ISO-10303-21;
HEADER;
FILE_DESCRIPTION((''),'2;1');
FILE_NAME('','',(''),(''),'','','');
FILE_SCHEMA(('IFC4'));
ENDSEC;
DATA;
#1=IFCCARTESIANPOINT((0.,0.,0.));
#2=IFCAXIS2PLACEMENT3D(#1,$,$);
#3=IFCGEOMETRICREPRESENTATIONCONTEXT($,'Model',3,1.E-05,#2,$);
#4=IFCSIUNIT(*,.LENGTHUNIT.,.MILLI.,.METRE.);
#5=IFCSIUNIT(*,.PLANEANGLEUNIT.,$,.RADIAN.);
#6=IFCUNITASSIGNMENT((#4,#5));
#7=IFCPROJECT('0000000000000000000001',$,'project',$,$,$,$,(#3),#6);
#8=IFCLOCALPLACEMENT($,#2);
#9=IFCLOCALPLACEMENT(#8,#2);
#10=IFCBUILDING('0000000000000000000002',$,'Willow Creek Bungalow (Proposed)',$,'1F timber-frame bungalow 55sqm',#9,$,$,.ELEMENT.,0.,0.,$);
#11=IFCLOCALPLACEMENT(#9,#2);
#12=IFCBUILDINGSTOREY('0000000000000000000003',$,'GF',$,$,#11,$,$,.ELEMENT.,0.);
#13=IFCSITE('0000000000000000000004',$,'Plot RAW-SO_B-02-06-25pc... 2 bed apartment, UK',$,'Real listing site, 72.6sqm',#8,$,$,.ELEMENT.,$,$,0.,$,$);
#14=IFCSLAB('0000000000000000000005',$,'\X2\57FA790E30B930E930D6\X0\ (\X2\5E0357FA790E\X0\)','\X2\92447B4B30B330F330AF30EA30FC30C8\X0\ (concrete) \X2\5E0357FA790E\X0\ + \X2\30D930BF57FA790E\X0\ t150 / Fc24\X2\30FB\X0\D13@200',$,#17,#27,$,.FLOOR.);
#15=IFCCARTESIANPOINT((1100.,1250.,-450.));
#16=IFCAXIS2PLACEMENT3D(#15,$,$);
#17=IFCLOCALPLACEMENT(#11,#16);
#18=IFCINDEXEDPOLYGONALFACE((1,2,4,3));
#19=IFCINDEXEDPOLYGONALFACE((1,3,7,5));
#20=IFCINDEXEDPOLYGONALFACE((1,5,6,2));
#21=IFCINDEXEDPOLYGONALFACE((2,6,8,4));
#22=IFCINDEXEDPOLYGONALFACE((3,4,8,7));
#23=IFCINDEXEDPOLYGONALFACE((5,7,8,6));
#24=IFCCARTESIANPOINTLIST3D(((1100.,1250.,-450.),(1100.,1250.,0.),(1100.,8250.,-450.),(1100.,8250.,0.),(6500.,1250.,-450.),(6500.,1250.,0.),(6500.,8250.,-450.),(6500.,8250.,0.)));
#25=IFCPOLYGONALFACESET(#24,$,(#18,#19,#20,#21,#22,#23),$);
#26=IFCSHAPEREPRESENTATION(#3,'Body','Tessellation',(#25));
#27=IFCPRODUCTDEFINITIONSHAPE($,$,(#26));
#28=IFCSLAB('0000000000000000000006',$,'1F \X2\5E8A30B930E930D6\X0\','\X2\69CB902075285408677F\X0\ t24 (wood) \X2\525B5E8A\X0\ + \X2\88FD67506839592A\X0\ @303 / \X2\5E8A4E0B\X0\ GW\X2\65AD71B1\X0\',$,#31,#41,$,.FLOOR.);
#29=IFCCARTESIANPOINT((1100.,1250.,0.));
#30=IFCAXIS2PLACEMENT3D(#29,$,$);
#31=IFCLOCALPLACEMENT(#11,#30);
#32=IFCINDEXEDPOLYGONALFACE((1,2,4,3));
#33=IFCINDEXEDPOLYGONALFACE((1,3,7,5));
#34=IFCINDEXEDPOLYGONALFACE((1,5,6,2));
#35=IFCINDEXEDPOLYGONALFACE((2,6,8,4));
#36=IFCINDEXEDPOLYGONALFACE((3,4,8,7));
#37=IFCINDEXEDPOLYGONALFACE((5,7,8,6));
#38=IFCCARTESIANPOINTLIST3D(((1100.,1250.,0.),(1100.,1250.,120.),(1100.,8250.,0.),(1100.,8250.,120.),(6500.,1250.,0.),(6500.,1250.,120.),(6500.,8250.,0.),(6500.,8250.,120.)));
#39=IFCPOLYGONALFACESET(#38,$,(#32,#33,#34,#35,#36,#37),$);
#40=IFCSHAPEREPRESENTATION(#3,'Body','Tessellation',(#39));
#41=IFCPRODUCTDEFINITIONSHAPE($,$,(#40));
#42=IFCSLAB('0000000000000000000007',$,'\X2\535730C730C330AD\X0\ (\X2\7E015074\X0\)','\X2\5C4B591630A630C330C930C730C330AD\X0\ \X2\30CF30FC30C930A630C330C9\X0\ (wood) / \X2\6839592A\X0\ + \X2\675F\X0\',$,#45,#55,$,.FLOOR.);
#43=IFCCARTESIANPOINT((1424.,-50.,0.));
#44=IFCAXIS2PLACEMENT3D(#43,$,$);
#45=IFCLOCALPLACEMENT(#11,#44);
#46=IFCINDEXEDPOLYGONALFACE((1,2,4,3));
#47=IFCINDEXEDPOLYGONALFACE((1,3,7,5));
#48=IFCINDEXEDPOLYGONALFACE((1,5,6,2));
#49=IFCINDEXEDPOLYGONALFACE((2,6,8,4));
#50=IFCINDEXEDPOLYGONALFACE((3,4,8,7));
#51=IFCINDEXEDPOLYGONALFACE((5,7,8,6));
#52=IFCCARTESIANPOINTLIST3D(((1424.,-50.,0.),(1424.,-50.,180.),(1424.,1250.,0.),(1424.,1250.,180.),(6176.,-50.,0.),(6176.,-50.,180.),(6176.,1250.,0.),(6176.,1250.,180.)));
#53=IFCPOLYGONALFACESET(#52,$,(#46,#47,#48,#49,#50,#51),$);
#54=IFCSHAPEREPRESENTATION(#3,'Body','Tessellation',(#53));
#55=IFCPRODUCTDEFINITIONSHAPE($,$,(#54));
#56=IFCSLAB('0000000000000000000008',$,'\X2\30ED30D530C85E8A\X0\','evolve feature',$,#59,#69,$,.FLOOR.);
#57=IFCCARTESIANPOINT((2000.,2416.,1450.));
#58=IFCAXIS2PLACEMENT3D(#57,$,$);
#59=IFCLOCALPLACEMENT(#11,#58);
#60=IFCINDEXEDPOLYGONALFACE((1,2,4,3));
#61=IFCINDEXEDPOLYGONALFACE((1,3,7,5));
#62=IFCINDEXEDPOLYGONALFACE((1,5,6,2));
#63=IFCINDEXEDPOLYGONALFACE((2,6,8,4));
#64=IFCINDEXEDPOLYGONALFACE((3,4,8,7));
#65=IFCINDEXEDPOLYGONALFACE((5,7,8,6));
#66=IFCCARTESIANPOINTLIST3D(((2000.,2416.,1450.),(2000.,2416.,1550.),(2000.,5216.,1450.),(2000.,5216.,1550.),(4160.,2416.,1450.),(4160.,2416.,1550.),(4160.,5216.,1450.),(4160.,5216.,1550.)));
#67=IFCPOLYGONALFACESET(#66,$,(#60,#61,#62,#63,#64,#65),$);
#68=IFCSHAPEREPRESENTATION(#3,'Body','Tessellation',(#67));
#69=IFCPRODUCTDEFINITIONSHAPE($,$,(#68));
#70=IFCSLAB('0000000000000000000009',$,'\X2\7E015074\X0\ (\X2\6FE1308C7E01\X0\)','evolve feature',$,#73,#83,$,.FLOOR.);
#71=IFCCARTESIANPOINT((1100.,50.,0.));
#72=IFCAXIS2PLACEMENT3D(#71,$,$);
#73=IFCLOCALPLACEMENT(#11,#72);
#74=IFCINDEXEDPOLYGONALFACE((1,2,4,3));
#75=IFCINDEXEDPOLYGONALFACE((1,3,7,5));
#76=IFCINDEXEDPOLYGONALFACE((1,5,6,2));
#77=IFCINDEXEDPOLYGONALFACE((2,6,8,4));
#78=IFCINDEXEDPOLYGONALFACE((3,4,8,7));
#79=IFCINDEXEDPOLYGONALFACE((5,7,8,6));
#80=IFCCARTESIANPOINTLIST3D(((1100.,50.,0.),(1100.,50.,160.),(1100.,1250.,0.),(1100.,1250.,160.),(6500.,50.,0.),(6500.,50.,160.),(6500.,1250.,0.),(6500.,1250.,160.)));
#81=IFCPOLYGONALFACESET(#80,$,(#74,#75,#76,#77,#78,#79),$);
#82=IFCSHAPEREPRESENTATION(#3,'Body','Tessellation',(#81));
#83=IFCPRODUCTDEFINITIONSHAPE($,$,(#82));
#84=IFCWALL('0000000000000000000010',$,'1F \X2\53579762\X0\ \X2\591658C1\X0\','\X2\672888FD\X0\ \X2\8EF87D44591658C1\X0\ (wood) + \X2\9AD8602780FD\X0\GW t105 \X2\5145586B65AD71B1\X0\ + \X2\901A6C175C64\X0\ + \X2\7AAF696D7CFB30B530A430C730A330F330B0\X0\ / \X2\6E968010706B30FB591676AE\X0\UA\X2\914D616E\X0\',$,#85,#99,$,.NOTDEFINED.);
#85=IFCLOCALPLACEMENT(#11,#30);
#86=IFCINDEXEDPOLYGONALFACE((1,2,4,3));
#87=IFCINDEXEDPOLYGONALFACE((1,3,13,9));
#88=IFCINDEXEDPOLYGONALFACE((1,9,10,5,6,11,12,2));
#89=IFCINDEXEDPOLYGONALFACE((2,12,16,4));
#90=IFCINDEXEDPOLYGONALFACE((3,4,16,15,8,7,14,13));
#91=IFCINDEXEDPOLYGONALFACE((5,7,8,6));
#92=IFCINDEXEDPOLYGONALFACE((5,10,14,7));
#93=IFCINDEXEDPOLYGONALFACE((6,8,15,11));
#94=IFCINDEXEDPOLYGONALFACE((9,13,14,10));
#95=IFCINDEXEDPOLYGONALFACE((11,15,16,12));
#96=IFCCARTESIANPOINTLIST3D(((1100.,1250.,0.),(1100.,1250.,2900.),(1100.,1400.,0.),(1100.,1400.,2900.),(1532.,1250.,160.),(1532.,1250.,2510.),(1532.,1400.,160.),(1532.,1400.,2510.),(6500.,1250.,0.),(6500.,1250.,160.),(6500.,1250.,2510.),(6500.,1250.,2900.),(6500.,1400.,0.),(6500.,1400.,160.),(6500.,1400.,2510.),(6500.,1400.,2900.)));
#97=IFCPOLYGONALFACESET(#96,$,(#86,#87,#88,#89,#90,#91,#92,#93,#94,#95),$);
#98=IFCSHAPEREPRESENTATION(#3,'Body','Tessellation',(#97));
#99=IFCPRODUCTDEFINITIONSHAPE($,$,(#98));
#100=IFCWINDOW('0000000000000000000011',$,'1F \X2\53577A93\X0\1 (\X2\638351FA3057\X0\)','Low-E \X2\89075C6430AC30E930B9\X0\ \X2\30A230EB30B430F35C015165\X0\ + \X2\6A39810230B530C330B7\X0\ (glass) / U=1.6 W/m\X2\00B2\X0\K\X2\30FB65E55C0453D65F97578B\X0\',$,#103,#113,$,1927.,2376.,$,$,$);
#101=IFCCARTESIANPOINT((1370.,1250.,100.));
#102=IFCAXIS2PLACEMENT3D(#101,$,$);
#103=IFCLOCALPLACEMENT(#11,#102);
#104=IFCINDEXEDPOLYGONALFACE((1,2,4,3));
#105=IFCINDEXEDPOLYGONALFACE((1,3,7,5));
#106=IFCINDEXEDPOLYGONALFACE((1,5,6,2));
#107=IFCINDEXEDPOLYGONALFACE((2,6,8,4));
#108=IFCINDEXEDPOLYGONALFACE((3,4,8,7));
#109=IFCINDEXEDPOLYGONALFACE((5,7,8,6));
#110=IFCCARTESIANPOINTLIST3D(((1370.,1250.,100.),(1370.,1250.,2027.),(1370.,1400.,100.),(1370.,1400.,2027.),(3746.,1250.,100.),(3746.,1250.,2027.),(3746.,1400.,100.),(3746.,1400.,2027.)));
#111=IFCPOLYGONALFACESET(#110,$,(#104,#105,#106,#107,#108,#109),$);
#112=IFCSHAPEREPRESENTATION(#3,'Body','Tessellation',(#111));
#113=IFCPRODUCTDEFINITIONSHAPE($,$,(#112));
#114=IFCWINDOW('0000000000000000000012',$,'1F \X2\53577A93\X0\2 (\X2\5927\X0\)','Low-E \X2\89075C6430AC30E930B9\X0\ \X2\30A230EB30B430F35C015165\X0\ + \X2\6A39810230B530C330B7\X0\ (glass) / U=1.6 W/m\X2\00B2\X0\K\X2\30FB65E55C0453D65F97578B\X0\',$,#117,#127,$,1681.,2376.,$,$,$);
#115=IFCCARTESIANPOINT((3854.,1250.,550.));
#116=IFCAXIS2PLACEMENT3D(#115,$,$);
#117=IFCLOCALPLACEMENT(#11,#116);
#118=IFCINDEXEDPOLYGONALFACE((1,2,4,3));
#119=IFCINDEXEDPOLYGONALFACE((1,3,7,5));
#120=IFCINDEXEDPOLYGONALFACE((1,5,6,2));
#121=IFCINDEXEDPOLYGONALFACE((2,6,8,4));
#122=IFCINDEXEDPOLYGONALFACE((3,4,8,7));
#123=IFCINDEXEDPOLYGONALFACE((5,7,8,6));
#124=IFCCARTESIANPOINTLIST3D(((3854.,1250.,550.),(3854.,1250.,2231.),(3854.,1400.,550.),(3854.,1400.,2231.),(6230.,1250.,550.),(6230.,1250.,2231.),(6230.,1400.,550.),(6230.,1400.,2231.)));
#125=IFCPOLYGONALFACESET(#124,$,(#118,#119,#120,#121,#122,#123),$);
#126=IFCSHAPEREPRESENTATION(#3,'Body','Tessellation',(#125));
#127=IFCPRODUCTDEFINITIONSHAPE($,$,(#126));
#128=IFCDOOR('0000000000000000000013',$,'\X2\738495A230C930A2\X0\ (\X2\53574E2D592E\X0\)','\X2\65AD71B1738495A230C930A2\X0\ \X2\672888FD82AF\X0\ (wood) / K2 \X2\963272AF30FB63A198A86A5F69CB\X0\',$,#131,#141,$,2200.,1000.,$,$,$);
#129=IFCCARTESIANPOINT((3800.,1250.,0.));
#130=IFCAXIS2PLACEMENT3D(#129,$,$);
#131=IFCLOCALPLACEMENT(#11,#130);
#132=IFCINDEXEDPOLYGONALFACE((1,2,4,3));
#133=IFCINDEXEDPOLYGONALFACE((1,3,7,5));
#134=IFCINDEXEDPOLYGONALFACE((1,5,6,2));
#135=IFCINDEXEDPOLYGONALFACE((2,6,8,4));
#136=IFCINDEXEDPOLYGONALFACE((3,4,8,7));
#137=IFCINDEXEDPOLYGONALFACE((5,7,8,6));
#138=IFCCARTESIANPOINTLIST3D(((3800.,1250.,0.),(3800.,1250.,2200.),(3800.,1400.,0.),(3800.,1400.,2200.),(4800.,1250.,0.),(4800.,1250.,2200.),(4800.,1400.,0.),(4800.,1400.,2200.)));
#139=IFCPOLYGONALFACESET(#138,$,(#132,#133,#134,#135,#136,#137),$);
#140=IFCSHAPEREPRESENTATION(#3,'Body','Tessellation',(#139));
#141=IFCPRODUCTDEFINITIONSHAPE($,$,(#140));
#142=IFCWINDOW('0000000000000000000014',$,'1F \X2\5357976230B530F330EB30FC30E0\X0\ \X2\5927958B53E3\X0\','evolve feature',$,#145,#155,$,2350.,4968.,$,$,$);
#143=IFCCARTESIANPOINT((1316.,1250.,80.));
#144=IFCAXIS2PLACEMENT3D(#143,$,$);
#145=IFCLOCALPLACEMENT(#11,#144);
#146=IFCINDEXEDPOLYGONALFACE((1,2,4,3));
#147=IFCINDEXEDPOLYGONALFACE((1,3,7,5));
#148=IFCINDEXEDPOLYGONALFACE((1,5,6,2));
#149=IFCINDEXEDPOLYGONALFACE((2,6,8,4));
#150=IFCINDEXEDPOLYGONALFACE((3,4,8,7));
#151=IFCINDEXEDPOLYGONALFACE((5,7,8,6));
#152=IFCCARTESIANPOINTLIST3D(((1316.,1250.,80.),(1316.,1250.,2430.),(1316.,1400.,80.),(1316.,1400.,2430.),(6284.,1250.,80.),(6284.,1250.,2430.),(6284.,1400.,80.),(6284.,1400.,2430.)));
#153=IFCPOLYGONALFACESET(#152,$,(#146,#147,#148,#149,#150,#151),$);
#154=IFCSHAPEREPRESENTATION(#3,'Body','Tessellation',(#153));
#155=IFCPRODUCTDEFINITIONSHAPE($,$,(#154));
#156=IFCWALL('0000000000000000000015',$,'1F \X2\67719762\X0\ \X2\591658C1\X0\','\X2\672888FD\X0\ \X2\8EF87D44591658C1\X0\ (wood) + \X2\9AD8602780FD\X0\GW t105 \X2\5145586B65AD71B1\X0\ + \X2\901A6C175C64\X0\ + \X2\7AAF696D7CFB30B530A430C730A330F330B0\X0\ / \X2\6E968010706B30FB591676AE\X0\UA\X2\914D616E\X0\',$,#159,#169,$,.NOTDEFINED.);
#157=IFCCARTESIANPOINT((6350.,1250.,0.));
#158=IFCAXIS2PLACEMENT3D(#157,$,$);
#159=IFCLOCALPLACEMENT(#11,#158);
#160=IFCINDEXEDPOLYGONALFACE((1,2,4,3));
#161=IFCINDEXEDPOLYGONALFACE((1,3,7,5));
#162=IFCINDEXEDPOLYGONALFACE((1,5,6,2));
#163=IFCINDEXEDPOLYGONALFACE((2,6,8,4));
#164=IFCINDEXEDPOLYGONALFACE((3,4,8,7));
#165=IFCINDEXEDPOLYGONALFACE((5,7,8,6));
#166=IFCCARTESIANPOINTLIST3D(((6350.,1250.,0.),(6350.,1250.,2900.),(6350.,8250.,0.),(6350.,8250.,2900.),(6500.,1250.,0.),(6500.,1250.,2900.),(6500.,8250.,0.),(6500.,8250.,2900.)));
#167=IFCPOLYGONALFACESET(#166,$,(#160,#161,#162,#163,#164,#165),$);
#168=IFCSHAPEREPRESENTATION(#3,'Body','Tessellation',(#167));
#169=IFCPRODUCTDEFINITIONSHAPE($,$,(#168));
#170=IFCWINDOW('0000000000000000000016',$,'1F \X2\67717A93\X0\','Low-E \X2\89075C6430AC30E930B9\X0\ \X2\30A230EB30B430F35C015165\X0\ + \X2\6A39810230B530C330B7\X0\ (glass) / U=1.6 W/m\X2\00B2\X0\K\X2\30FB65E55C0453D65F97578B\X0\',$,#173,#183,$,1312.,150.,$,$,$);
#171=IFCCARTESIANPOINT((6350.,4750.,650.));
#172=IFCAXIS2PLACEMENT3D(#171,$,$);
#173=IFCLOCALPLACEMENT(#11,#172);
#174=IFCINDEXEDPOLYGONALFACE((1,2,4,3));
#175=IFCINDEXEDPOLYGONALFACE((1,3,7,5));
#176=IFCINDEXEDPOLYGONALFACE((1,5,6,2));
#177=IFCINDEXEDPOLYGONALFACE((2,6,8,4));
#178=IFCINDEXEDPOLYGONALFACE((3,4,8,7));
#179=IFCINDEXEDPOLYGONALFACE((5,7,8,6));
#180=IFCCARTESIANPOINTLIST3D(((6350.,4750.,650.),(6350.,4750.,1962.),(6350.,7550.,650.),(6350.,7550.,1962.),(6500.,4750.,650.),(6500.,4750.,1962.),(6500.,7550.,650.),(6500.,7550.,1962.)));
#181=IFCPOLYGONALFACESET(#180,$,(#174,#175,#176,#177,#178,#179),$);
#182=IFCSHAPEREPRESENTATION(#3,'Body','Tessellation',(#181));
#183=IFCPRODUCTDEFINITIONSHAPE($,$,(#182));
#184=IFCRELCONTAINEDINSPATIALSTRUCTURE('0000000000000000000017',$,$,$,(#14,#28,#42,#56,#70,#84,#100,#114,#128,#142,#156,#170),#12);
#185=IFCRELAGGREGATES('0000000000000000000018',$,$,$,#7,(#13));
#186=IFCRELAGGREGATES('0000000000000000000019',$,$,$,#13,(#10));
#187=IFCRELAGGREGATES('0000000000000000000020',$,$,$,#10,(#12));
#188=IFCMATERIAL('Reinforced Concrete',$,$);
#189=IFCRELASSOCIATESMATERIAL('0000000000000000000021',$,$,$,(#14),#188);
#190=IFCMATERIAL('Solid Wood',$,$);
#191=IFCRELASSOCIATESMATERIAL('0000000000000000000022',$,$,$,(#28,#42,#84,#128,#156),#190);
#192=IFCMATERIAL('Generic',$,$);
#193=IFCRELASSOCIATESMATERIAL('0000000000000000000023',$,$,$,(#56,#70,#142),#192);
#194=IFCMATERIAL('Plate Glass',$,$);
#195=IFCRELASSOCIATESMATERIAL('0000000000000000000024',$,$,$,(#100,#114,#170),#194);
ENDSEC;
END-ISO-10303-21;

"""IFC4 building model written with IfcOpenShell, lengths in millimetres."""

from ifc_helpers import new_model, si_unit, frame, frame_2d, origin, place, context, project, spatial, rectangle, extrude, material, element, fill, save


model = new_model("IFC4")

# Units and contexts
model_context = context("Model", 3, precision=1e-05, world=origin())
ifc_project = project(units=[si_unit("LENGTHUNIT", "METRE", prefix="MILLI"), si_unit("PLANEANGLEUNIT", "RADIAN")], contexts=[model_context])

# Site, building, storey
site_placement = place(None, origin())
site = spatial("IfcSite", under=ifc_project, at=site_placement, Name="Plot RAW-SO_B-02-06-25pc... 2 bed apartment, UK", ObjectType="Real listing site, 72.6sqm", CompositionType="ELEMENT", RefElevation=0.0)
building_placement = place(site_placement, origin())
building = spatial("IfcBuilding", under=site, at=building_placement, Name="Willow Creek Bungalow (Proposed)", ObjectType="1F timber-frame bungalow 55sqm", CompositionType="ELEMENT", ElevationOfRefHeight=0.0, ElevationOfTerrain=0.0)
storey_placement = place(building_placement, origin())
storey = spatial("IfcBuildingStorey", under=building, at=storey_placement, Name="GF", CompositionType="ELEMENT", Elevation=0.0)

# Slabs
ifc_material_1 = material(Name="Reinforced Concrete")
slab_1_placement = place(storey_placement, frame((1100.0, 1250.0, -450.0)))
element("IfcSlab", 1, at=slab_1_placement, inside=storey, material=ifc_material_1, Name="基礎スラブ (布基礎)", Description="鉄筋コンクリート (concrete) 布基礎 + ベタ基礎 t150 / Fc24・D13@200", PredefinedType="FLOOR", context=model_context, shape_type="SweptSolid", body=[
    extrude(rectangle(XDim=5400.0, YDim=7000.0, at=frame_2d((2700.0, 3500.0))), frame((1100.0, 1250.0, -450.0)), (0.0, 0.0, 1.0), 450.0),
])
ifc_material_2 = material(Name="Solid Wood")
slab_2_placement = place(storey_placement, frame((1100.0, 1250.0, 0.0)))
element("IfcSlab", 2, at=slab_2_placement, inside=storey, material=ifc_material_2, Name="1F 床スラブ", Description="構造用合板 t24 (wood) 剛床 + 製材根太 @303 / 床下 GW断熱", PredefinedType="FLOOR", context=model_context, shape_type="SweptSolid", body=[
    extrude(rectangle(XDim=5400.0, YDim=7000.0, at=frame_2d((2700.0, 3500.0))), frame((1100.0, 1250.0, 0.0)), (0.0, 0.0, 1.0), 120.0),
])
slab_3_placement = place(storey_placement, frame((1424.0, -50.0, 0.0)))
element("IfcSlab", 3, at=slab_3_placement, inside=storey, material=ifc_material_2, Name="南デッキ (縁側)", Description="屋外ウッドデッキ ハードウッド (wood) / 根太 + 束", PredefinedType="FLOOR", context=model_context, shape_type="SweptSolid", body=[
    extrude(rectangle(XDim=4752.0, YDim=1300.0, at=frame_2d((2376.0, 650.0))), frame((1424.0, -50.0, 0.0)), (0.0, 0.0, 1.0), 180.0),
])
ifc_material_3 = material(Name="Generic")
slab_4_placement = place(storey_placement, frame((2000.0, 2416.0, 1450.0)))
element("IfcSlab", 4, at=slab_4_placement, inside=storey, material=ifc_material_3, Name="ロフト床", Description="evolve feature", PredefinedType="FLOOR", context=model_context, shape_type="SweptSolid", body=[
    extrude(rectangle(XDim=2160.0, YDim=2800.0, at=frame_2d((1080.0, 1400.0))), frame((2000.0, 2416.0, 1450.0)), (0.0, 0.0, 1.0), 100.0),
])
slab_5_placement = place(storey_placement, frame((1100.0, 50.0, 0.0)))
element("IfcSlab", 5, at=slab_5_placement, inside=storey, material=ifc_material_3, Name="縁側 (濡れ縁)", Description="evolve feature", PredefinedType="FLOOR", context=model_context, shape_type="SweptSolid", body=[
    extrude(rectangle(XDim=5400.0, YDim=1200.0, at=frame_2d((2700.0, 600.0))), frame((1100.0, 50.0, 0.0)), (0.0, 0.0, 1.0), 160.0),
])

# Wall, openings, windows, door
wall_1_placement = place(storey_placement, frame((1100.0, 1250.0, 0.0)))
wall_1 = element("IfcWall", 6, at=wall_1_placement, inside=storey, material=ifc_material_2, Name="1F 南面 外壁", Description="木製 軸組外壁 (wood) + 高性能GW t105 充填断熱 + 通気層 + 窯業系サイディング / 準耐火・外皮UA配慮", PredefinedType="NOTDEFINED", context=model_context, shape_type="SweptSolid", body=[
    extrude(rectangle(XDim=5400.0, YDim=150.0, at=frame_2d((2700.0, 75.0))), frame((1100.0, 1250.0, 0.0)), (0.0, 0.0, 1.0), 2900.0),
])
opening_1_placement = place(storey_placement, frame((1370.0, 1250.0, 100.0)))
opening_1 = element("IfcOpeningElement", 7, at=opening_1_placement, cuts=wall_1, PredefinedType="NOTDEFINED", context=model_context, shape_type="SweptSolid", body=[
    extrude(rectangle(XDim=2376.0, YDim=150.0, at=frame_2d((1188.0, 75.0))), frame((1370.0, 1250.0, 100.0)), (0.0, 0.0, 1.0), 1927.0),
])
opening_2_placement = place(storey_placement, frame((3854.0, 1250.0, 550.0)))
opening_2 = element("IfcOpeningElement", 8, at=opening_2_placement, cuts=wall_1, PredefinedType="NOTDEFINED", context=model_context, shape_type="SweptSolid", body=[
    extrude(rectangle(XDim=2376.0, YDim=150.0, at=frame_2d((1188.0, 75.0))), frame((3854.0, 1250.0, 550.0)), (0.0, 0.0, 1.0), 1681.0),
])
opening_3_placement = place(storey_placement, frame((3800.0, 1250.0, 0.0)))
opening_3 = element("IfcOpeningElement", 9, at=opening_3_placement, cuts=wall_1, PredefinedType="NOTDEFINED", context=model_context, shape_type="SweptSolid", body=[
    extrude(rectangle(XDim=1000.0, YDim=150.0, at=frame_2d((500.0, 75.0))), frame((3800.0, 1250.0, 0.0)), (0.0, 0.0, 1.0), 2200.0),
])
opening_4_placement = place(storey_placement, frame((1316.0, 1250.0, 80.0)))
opening_4 = element("IfcOpeningElement", 10, at=opening_4_placement, cuts=wall_1, PredefinedType="NOTDEFINED", context=model_context, shape_type="SweptSolid", body=[
    extrude(rectangle(XDim=4968.0, YDim=150.0, at=frame_2d((2484.0, 75.0))), frame((1316.0, 1250.0, 80.0)), (0.0, 0.0, 1.0), 2350.0),
])
ifc_material_4 = material(Name="Plate Glass")
window_1_placement = place(storey_placement, frame((1370.0, 1250.0, 100.0)))
window_1 = element("IfcWindow", 11, at=window_1_placement, inside=storey, material=ifc_material_4, Name="1F 南窓1 (掃出し)", Description="Low-E 複層ガラス アルゴン封入 + 樹脂サッシ (glass) / U=1.6 W/m²K・日射取得型", OverallHeight=1927.0, OverallWidth=2376.0, context=model_context, shape_type="SweptSolid", body=[
    extrude(rectangle(XDim=2376.0, YDim=150.0, at=frame_2d((1188.0, 75.0))), frame((1370.0, 1250.0, 100.0)), (0.0, 0.0, 1.0), 1927.0),
])
fill(opening_1, window_1)
window_2_placement = place(storey_placement, frame((3854.0, 1250.0, 550.0)))
window_2 = element("IfcWindow", 12, at=window_2_placement, inside=storey, material=ifc_material_4, Name="1F 南窓2 (大)", Description="Low-E 複層ガラス アルゴン封入 + 樹脂サッシ (glass) / U=1.6 W/m²K・日射取得型", OverallHeight=1681.0, OverallWidth=2376.0, context=model_context, shape_type="SweptSolid", body=[
    extrude(rectangle(XDim=2376.0, YDim=150.0, at=frame_2d((1188.0, 75.0))), frame((3854.0, 1250.0, 550.0)), (0.0, 0.0, 1.0), 1681.0),
])
fill(opening_2, window_2)
door_placement = place(storey_placement, frame((3800.0, 1250.0, 0.0)))
door = element("IfcDoor", 13, at=door_placement, inside=storey, material=ifc_material_2, Name="玄関ドア (南中央)", Description="断熱玄関ドア 木製芯 (wood) / K2 防犯・採風機構", OverallHeight=2200.0, OverallWidth=1000.0, context=model_context, shape_type="SweptSolid", body=[
    extrude(rectangle(XDim=1000.0, YDim=150.0, at=frame_2d((500.0, 75.0))), frame((3800.0, 1250.0, 0.0)), (0.0, 0.0, 1.0), 2200.0),
])
fill(opening_3, door)
window_3_placement = place(storey_placement, frame((1316.0, 1250.0, 80.0)))
window_3 = element("IfcWindow", 14, at=window_3_placement, inside=storey, material=ifc_material_3, Name="1F 南面サンルーム 大開口", Description="evolve feature", OverallHeight=2350.0, OverallWidth=4968.0, context=model_context, shape_type="SweptSolid", body=[
    extrude(rectangle(XDim=4968.0, YDim=150.0, at=frame_2d((2484.0, 75.0))), frame((1316.0, 1250.0, 80.0)), (0.0, 0.0, 1.0), 2350.0),
])
fill(opening_4, window_3)

# Wall, opening, window
wall_2_placement = place(storey_placement, frame((6350.0, 1250.0, 0.0)))
wall_2 = element("IfcWall", 15, at=wall_2_placement, inside=storey, material=ifc_material_2, Name="1F 東面 外壁", Description="木製 軸組外壁 (wood) + 高性能GW t105 充填断熱 + 通気層 + 窯業系サイディング / 準耐火・外皮UA配慮", PredefinedType="NOTDEFINED", context=model_context, shape_type="SweptSolid", body=[
    extrude(rectangle(XDim=150.0, YDim=7000.0, at=frame_2d((75.0, 3500.0))), frame((6350.0, 1250.0, 0.0)), (0.0, 0.0, 1.0), 2900.0),
])
opening_5_placement = place(storey_placement, frame((6350.0, 4750.0, 650.0)))
opening_5 = element("IfcOpeningElement", 16, at=opening_5_placement, cuts=wall_2, PredefinedType="NOTDEFINED", context=model_context, shape_type="SweptSolid", body=[
    extrude(rectangle(XDim=150.0, YDim=2800.0, at=frame_2d((75.0, 1400.0))), frame((6350.0, 4750.0, 650.0)), (0.0, 0.0, 1.0), 1312.0),
])
window_4_placement = place(storey_placement, frame((6350.0, 4750.0, 650.0)))
window_4 = element("IfcWindow", 17, at=window_4_placement, inside=storey, material=ifc_material_4, Name="1F 東窓", Description="Low-E 複層ガラス アルゴン封入 + 樹脂サッシ (glass) / U=1.6 W/m²K・日射取得型", OverallHeight=1312.0, OverallWidth=150.0, context=model_context, shape_type="SweptSolid", body=[
    extrude(rectangle(XDim=150.0, YDim=2800.0, at=frame_2d((75.0, 1400.0))), frame((6350.0, 4750.0, 650.0)), (0.0, 0.0, 1.0), 1312.0),
])
fill(opening_5, window_4)

save(model, "model.ifc")
